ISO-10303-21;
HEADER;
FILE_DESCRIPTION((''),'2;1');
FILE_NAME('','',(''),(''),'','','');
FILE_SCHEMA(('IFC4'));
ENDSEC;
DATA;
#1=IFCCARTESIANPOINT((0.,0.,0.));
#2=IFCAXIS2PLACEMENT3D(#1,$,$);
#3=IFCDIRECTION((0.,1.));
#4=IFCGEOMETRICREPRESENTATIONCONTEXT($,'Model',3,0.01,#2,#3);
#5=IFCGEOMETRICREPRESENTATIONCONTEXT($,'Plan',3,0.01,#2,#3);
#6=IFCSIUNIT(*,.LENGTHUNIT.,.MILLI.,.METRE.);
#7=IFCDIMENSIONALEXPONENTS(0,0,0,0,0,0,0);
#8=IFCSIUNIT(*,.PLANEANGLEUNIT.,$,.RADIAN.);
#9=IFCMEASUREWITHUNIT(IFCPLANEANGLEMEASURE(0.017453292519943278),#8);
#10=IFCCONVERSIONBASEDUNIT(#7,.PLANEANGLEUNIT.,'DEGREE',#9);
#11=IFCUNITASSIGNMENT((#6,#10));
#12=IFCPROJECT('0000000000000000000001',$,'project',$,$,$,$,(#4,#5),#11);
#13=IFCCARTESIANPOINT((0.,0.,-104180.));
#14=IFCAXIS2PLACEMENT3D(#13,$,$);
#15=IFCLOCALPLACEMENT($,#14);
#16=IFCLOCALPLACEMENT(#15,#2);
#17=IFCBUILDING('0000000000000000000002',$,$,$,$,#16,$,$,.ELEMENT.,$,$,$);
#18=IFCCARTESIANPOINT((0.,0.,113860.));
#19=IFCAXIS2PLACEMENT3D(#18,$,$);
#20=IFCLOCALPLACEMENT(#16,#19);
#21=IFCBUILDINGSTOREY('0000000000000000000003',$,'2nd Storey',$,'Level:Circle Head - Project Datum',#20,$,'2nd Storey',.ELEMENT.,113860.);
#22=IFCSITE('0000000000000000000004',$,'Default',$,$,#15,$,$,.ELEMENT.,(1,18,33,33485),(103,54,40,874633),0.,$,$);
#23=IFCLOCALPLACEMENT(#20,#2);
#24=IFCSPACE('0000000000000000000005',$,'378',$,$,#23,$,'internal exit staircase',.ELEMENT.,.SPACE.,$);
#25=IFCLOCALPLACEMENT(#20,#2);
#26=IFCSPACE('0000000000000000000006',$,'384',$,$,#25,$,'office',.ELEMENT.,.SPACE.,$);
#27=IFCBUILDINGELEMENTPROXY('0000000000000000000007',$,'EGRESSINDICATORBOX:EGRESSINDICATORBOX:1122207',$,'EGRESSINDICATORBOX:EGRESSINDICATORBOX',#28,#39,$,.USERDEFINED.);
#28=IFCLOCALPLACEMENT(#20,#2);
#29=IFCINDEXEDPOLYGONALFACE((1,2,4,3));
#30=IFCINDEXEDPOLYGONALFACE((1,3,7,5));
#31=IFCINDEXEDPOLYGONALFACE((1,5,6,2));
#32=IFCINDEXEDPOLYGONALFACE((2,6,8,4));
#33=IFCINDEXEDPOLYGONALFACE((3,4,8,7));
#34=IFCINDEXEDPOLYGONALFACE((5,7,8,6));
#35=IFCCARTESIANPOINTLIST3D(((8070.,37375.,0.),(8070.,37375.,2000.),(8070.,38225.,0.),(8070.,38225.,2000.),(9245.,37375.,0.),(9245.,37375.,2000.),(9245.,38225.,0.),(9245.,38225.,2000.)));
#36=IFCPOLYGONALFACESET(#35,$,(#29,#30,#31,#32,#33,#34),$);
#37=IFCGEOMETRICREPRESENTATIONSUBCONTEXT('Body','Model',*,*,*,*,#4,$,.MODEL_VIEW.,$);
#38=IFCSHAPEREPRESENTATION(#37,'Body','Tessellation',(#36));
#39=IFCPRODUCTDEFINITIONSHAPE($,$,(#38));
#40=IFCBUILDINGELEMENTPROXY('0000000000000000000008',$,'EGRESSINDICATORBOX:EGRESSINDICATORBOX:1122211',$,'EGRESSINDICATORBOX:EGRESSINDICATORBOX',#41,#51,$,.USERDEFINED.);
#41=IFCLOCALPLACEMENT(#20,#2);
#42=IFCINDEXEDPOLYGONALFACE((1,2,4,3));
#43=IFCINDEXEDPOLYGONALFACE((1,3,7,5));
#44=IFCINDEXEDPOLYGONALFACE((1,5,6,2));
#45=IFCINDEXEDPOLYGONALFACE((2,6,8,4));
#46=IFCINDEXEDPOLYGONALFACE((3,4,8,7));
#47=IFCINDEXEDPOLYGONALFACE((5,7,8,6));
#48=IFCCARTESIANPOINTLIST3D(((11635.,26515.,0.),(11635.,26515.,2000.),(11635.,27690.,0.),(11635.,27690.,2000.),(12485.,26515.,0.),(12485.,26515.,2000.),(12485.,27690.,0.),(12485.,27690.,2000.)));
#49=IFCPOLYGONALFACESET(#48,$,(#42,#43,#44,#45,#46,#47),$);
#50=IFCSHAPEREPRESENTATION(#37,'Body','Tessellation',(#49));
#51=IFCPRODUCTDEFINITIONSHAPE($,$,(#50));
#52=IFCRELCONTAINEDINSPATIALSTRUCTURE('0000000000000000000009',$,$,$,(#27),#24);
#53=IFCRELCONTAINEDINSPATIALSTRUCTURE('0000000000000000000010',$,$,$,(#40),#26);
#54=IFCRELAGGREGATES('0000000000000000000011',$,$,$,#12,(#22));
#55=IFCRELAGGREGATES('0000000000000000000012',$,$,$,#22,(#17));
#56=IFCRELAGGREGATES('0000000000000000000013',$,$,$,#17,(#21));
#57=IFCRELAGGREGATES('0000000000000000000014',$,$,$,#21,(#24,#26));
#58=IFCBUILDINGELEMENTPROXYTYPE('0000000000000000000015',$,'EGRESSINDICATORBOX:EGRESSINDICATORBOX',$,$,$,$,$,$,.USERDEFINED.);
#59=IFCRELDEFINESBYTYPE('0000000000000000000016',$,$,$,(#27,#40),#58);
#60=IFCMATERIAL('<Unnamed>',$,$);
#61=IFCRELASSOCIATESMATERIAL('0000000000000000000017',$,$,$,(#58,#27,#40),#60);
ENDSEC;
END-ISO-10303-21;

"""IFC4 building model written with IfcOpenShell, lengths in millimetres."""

from ifc_helpers import new_model, entity, si_unit, converted_unit, direction, frame, origin, place, context, subcontext, project, spatial, indexed_curve, outline, extrude, source, transform, mapped, material, type_object, type_shapes, element, save


model = new_model("IFC4")

# Units and contexts
model_context = context("Model", 3, precision=0.01, world=origin(), true_north=direction((0.0, 1.0)))
plan_context = context("Plan", 3, precision=0.01, world=origin(), true_north=direction((0.0, 1.0)))
body_context = subcontext(model_context, "Body", "Model", "MODEL_VIEW")
ifc_project = project(units=[si_unit("LENGTHUNIT", "METRE", prefix="MILLI"), converted_unit("PLANEANGLEUNIT", "DEGREE", entity("IfcPlaneAngleMeasure", 0.017453292519943278), si_unit("PLANEANGLEUNIT", "RADIAN"), dimensions=[0, 0, 0, 0, 0, 0, 0])], contexts=[model_context, plan_context])

# Site, building, storey
site_placement = place(None, frame((0.0, 0.0, -104180.0)))
site = spatial("IfcSite", under=ifc_project, at=site_placement, Name="Default", CompositionType="ELEMENT", RefLatitude=(1, 18, 33, 33485), RefLongitude=(103, 54, 40, 874633), RefElevation=0.0)
building_placement = place(site_placement, origin())
building = spatial("IfcBuilding", under=site, at=building_placement, CompositionType="ELEMENT")
storey_placement = place(building_placement, frame((0.0, 0.0, 113860.0)))
storey = spatial("IfcBuildingStorey", under=building, at=storey_placement, Name="2nd Storey", ObjectType="Level:Circle Head - Project Datum", LongName="2nd Storey", CompositionType="ELEMENT", Elevation=113860.0)

# Shared definitions
ifc_material_1 = material(Name="<Unnamed>")

# Shared definitions
building_element_proxy_type_1 = type_object("IfcBuildingElementProxyType", Name="EGRESSINDICATORBOX:EGRESSINDICATORBOX", PredefinedType="USERDEFINED", material=ifc_material_1)
shared_shape_1 = source(origin(), body_context, "Body", "SweptSolid", [
    extrude(outline(indexed_curve([(-425.0, -587.5), (425.0, -587.5), (425.0, 587.5), (-425.0, 587.5), (-425.0, -587.5)], self_intersect=False)), frame((0.0, 0.0, 0.0), z_axis=(0.0, 0.0, 1.0), x_axis=(-1.0, 0.0, 0.0)), (0.0, 0.0, 1.0), 2000.0),
])
type_shapes(building_element_proxy_type_1, [shared_shape_1])

# Shared definitions
space_1_placement = place(storey_placement, origin())
space_1 = spatial("IfcSpace", under=storey, at=space_1_placement, Name="378", LongName="internal exit staircase", CompositionType="ELEMENT", PredefinedType="SPACE")

# Building element proxy
proxy_1_placement = place(space_1_placement, frame((8657.5, 37800.0, 0.0), z_axis=(0.0, 0.0, 1.0), x_axis=(0.0, 1.0, 0.0)))
element("IfcBuildingElementProxy", 1, at=proxy_1_placement, inside=space_1, type_object=building_element_proxy_type_1, material=ifc_material_1, Name="EGRESSINDICATORBOX:EGRESSINDICATORBOX:1122207", ObjectType="EGRESSINDICATORBOX:EGRESSINDICATORBOX", PredefinedType="USERDEFINED", context=body_context, shape_type="MappedRepresentation", body=[
    mapped(shared_shape_1, transform((0.0, 0.0, 0.0), scale=1.0)),
])

# Shared definitions
space_2_placement = place(storey_placement, origin())
space_2 = spatial("IfcSpace", under=storey, at=space_2_placement, Name="384", LongName="office", CompositionType="ELEMENT", PredefinedType="SPACE")

# Building element proxy
proxy_2_placement = place(space_2_placement, frame((12060.0, 27102.5, 0.0)))
element("IfcBuildingElementProxy", 2, at=proxy_2_placement, inside=space_2, type_object=building_element_proxy_type_1, material=ifc_material_1, Name="EGRESSINDICATORBOX:EGRESSINDICATORBOX:1122211", ObjectType="EGRESSINDICATORBOX:EGRESSINDICATORBOX", PredefinedType="USERDEFINED", context=body_context, shape_type="MappedRepresentation", body=[
    mapped(shared_shape_1, transform((0.0, 0.0, 0.0), scale=1.0)),
])

save(model, "model.ifc")
